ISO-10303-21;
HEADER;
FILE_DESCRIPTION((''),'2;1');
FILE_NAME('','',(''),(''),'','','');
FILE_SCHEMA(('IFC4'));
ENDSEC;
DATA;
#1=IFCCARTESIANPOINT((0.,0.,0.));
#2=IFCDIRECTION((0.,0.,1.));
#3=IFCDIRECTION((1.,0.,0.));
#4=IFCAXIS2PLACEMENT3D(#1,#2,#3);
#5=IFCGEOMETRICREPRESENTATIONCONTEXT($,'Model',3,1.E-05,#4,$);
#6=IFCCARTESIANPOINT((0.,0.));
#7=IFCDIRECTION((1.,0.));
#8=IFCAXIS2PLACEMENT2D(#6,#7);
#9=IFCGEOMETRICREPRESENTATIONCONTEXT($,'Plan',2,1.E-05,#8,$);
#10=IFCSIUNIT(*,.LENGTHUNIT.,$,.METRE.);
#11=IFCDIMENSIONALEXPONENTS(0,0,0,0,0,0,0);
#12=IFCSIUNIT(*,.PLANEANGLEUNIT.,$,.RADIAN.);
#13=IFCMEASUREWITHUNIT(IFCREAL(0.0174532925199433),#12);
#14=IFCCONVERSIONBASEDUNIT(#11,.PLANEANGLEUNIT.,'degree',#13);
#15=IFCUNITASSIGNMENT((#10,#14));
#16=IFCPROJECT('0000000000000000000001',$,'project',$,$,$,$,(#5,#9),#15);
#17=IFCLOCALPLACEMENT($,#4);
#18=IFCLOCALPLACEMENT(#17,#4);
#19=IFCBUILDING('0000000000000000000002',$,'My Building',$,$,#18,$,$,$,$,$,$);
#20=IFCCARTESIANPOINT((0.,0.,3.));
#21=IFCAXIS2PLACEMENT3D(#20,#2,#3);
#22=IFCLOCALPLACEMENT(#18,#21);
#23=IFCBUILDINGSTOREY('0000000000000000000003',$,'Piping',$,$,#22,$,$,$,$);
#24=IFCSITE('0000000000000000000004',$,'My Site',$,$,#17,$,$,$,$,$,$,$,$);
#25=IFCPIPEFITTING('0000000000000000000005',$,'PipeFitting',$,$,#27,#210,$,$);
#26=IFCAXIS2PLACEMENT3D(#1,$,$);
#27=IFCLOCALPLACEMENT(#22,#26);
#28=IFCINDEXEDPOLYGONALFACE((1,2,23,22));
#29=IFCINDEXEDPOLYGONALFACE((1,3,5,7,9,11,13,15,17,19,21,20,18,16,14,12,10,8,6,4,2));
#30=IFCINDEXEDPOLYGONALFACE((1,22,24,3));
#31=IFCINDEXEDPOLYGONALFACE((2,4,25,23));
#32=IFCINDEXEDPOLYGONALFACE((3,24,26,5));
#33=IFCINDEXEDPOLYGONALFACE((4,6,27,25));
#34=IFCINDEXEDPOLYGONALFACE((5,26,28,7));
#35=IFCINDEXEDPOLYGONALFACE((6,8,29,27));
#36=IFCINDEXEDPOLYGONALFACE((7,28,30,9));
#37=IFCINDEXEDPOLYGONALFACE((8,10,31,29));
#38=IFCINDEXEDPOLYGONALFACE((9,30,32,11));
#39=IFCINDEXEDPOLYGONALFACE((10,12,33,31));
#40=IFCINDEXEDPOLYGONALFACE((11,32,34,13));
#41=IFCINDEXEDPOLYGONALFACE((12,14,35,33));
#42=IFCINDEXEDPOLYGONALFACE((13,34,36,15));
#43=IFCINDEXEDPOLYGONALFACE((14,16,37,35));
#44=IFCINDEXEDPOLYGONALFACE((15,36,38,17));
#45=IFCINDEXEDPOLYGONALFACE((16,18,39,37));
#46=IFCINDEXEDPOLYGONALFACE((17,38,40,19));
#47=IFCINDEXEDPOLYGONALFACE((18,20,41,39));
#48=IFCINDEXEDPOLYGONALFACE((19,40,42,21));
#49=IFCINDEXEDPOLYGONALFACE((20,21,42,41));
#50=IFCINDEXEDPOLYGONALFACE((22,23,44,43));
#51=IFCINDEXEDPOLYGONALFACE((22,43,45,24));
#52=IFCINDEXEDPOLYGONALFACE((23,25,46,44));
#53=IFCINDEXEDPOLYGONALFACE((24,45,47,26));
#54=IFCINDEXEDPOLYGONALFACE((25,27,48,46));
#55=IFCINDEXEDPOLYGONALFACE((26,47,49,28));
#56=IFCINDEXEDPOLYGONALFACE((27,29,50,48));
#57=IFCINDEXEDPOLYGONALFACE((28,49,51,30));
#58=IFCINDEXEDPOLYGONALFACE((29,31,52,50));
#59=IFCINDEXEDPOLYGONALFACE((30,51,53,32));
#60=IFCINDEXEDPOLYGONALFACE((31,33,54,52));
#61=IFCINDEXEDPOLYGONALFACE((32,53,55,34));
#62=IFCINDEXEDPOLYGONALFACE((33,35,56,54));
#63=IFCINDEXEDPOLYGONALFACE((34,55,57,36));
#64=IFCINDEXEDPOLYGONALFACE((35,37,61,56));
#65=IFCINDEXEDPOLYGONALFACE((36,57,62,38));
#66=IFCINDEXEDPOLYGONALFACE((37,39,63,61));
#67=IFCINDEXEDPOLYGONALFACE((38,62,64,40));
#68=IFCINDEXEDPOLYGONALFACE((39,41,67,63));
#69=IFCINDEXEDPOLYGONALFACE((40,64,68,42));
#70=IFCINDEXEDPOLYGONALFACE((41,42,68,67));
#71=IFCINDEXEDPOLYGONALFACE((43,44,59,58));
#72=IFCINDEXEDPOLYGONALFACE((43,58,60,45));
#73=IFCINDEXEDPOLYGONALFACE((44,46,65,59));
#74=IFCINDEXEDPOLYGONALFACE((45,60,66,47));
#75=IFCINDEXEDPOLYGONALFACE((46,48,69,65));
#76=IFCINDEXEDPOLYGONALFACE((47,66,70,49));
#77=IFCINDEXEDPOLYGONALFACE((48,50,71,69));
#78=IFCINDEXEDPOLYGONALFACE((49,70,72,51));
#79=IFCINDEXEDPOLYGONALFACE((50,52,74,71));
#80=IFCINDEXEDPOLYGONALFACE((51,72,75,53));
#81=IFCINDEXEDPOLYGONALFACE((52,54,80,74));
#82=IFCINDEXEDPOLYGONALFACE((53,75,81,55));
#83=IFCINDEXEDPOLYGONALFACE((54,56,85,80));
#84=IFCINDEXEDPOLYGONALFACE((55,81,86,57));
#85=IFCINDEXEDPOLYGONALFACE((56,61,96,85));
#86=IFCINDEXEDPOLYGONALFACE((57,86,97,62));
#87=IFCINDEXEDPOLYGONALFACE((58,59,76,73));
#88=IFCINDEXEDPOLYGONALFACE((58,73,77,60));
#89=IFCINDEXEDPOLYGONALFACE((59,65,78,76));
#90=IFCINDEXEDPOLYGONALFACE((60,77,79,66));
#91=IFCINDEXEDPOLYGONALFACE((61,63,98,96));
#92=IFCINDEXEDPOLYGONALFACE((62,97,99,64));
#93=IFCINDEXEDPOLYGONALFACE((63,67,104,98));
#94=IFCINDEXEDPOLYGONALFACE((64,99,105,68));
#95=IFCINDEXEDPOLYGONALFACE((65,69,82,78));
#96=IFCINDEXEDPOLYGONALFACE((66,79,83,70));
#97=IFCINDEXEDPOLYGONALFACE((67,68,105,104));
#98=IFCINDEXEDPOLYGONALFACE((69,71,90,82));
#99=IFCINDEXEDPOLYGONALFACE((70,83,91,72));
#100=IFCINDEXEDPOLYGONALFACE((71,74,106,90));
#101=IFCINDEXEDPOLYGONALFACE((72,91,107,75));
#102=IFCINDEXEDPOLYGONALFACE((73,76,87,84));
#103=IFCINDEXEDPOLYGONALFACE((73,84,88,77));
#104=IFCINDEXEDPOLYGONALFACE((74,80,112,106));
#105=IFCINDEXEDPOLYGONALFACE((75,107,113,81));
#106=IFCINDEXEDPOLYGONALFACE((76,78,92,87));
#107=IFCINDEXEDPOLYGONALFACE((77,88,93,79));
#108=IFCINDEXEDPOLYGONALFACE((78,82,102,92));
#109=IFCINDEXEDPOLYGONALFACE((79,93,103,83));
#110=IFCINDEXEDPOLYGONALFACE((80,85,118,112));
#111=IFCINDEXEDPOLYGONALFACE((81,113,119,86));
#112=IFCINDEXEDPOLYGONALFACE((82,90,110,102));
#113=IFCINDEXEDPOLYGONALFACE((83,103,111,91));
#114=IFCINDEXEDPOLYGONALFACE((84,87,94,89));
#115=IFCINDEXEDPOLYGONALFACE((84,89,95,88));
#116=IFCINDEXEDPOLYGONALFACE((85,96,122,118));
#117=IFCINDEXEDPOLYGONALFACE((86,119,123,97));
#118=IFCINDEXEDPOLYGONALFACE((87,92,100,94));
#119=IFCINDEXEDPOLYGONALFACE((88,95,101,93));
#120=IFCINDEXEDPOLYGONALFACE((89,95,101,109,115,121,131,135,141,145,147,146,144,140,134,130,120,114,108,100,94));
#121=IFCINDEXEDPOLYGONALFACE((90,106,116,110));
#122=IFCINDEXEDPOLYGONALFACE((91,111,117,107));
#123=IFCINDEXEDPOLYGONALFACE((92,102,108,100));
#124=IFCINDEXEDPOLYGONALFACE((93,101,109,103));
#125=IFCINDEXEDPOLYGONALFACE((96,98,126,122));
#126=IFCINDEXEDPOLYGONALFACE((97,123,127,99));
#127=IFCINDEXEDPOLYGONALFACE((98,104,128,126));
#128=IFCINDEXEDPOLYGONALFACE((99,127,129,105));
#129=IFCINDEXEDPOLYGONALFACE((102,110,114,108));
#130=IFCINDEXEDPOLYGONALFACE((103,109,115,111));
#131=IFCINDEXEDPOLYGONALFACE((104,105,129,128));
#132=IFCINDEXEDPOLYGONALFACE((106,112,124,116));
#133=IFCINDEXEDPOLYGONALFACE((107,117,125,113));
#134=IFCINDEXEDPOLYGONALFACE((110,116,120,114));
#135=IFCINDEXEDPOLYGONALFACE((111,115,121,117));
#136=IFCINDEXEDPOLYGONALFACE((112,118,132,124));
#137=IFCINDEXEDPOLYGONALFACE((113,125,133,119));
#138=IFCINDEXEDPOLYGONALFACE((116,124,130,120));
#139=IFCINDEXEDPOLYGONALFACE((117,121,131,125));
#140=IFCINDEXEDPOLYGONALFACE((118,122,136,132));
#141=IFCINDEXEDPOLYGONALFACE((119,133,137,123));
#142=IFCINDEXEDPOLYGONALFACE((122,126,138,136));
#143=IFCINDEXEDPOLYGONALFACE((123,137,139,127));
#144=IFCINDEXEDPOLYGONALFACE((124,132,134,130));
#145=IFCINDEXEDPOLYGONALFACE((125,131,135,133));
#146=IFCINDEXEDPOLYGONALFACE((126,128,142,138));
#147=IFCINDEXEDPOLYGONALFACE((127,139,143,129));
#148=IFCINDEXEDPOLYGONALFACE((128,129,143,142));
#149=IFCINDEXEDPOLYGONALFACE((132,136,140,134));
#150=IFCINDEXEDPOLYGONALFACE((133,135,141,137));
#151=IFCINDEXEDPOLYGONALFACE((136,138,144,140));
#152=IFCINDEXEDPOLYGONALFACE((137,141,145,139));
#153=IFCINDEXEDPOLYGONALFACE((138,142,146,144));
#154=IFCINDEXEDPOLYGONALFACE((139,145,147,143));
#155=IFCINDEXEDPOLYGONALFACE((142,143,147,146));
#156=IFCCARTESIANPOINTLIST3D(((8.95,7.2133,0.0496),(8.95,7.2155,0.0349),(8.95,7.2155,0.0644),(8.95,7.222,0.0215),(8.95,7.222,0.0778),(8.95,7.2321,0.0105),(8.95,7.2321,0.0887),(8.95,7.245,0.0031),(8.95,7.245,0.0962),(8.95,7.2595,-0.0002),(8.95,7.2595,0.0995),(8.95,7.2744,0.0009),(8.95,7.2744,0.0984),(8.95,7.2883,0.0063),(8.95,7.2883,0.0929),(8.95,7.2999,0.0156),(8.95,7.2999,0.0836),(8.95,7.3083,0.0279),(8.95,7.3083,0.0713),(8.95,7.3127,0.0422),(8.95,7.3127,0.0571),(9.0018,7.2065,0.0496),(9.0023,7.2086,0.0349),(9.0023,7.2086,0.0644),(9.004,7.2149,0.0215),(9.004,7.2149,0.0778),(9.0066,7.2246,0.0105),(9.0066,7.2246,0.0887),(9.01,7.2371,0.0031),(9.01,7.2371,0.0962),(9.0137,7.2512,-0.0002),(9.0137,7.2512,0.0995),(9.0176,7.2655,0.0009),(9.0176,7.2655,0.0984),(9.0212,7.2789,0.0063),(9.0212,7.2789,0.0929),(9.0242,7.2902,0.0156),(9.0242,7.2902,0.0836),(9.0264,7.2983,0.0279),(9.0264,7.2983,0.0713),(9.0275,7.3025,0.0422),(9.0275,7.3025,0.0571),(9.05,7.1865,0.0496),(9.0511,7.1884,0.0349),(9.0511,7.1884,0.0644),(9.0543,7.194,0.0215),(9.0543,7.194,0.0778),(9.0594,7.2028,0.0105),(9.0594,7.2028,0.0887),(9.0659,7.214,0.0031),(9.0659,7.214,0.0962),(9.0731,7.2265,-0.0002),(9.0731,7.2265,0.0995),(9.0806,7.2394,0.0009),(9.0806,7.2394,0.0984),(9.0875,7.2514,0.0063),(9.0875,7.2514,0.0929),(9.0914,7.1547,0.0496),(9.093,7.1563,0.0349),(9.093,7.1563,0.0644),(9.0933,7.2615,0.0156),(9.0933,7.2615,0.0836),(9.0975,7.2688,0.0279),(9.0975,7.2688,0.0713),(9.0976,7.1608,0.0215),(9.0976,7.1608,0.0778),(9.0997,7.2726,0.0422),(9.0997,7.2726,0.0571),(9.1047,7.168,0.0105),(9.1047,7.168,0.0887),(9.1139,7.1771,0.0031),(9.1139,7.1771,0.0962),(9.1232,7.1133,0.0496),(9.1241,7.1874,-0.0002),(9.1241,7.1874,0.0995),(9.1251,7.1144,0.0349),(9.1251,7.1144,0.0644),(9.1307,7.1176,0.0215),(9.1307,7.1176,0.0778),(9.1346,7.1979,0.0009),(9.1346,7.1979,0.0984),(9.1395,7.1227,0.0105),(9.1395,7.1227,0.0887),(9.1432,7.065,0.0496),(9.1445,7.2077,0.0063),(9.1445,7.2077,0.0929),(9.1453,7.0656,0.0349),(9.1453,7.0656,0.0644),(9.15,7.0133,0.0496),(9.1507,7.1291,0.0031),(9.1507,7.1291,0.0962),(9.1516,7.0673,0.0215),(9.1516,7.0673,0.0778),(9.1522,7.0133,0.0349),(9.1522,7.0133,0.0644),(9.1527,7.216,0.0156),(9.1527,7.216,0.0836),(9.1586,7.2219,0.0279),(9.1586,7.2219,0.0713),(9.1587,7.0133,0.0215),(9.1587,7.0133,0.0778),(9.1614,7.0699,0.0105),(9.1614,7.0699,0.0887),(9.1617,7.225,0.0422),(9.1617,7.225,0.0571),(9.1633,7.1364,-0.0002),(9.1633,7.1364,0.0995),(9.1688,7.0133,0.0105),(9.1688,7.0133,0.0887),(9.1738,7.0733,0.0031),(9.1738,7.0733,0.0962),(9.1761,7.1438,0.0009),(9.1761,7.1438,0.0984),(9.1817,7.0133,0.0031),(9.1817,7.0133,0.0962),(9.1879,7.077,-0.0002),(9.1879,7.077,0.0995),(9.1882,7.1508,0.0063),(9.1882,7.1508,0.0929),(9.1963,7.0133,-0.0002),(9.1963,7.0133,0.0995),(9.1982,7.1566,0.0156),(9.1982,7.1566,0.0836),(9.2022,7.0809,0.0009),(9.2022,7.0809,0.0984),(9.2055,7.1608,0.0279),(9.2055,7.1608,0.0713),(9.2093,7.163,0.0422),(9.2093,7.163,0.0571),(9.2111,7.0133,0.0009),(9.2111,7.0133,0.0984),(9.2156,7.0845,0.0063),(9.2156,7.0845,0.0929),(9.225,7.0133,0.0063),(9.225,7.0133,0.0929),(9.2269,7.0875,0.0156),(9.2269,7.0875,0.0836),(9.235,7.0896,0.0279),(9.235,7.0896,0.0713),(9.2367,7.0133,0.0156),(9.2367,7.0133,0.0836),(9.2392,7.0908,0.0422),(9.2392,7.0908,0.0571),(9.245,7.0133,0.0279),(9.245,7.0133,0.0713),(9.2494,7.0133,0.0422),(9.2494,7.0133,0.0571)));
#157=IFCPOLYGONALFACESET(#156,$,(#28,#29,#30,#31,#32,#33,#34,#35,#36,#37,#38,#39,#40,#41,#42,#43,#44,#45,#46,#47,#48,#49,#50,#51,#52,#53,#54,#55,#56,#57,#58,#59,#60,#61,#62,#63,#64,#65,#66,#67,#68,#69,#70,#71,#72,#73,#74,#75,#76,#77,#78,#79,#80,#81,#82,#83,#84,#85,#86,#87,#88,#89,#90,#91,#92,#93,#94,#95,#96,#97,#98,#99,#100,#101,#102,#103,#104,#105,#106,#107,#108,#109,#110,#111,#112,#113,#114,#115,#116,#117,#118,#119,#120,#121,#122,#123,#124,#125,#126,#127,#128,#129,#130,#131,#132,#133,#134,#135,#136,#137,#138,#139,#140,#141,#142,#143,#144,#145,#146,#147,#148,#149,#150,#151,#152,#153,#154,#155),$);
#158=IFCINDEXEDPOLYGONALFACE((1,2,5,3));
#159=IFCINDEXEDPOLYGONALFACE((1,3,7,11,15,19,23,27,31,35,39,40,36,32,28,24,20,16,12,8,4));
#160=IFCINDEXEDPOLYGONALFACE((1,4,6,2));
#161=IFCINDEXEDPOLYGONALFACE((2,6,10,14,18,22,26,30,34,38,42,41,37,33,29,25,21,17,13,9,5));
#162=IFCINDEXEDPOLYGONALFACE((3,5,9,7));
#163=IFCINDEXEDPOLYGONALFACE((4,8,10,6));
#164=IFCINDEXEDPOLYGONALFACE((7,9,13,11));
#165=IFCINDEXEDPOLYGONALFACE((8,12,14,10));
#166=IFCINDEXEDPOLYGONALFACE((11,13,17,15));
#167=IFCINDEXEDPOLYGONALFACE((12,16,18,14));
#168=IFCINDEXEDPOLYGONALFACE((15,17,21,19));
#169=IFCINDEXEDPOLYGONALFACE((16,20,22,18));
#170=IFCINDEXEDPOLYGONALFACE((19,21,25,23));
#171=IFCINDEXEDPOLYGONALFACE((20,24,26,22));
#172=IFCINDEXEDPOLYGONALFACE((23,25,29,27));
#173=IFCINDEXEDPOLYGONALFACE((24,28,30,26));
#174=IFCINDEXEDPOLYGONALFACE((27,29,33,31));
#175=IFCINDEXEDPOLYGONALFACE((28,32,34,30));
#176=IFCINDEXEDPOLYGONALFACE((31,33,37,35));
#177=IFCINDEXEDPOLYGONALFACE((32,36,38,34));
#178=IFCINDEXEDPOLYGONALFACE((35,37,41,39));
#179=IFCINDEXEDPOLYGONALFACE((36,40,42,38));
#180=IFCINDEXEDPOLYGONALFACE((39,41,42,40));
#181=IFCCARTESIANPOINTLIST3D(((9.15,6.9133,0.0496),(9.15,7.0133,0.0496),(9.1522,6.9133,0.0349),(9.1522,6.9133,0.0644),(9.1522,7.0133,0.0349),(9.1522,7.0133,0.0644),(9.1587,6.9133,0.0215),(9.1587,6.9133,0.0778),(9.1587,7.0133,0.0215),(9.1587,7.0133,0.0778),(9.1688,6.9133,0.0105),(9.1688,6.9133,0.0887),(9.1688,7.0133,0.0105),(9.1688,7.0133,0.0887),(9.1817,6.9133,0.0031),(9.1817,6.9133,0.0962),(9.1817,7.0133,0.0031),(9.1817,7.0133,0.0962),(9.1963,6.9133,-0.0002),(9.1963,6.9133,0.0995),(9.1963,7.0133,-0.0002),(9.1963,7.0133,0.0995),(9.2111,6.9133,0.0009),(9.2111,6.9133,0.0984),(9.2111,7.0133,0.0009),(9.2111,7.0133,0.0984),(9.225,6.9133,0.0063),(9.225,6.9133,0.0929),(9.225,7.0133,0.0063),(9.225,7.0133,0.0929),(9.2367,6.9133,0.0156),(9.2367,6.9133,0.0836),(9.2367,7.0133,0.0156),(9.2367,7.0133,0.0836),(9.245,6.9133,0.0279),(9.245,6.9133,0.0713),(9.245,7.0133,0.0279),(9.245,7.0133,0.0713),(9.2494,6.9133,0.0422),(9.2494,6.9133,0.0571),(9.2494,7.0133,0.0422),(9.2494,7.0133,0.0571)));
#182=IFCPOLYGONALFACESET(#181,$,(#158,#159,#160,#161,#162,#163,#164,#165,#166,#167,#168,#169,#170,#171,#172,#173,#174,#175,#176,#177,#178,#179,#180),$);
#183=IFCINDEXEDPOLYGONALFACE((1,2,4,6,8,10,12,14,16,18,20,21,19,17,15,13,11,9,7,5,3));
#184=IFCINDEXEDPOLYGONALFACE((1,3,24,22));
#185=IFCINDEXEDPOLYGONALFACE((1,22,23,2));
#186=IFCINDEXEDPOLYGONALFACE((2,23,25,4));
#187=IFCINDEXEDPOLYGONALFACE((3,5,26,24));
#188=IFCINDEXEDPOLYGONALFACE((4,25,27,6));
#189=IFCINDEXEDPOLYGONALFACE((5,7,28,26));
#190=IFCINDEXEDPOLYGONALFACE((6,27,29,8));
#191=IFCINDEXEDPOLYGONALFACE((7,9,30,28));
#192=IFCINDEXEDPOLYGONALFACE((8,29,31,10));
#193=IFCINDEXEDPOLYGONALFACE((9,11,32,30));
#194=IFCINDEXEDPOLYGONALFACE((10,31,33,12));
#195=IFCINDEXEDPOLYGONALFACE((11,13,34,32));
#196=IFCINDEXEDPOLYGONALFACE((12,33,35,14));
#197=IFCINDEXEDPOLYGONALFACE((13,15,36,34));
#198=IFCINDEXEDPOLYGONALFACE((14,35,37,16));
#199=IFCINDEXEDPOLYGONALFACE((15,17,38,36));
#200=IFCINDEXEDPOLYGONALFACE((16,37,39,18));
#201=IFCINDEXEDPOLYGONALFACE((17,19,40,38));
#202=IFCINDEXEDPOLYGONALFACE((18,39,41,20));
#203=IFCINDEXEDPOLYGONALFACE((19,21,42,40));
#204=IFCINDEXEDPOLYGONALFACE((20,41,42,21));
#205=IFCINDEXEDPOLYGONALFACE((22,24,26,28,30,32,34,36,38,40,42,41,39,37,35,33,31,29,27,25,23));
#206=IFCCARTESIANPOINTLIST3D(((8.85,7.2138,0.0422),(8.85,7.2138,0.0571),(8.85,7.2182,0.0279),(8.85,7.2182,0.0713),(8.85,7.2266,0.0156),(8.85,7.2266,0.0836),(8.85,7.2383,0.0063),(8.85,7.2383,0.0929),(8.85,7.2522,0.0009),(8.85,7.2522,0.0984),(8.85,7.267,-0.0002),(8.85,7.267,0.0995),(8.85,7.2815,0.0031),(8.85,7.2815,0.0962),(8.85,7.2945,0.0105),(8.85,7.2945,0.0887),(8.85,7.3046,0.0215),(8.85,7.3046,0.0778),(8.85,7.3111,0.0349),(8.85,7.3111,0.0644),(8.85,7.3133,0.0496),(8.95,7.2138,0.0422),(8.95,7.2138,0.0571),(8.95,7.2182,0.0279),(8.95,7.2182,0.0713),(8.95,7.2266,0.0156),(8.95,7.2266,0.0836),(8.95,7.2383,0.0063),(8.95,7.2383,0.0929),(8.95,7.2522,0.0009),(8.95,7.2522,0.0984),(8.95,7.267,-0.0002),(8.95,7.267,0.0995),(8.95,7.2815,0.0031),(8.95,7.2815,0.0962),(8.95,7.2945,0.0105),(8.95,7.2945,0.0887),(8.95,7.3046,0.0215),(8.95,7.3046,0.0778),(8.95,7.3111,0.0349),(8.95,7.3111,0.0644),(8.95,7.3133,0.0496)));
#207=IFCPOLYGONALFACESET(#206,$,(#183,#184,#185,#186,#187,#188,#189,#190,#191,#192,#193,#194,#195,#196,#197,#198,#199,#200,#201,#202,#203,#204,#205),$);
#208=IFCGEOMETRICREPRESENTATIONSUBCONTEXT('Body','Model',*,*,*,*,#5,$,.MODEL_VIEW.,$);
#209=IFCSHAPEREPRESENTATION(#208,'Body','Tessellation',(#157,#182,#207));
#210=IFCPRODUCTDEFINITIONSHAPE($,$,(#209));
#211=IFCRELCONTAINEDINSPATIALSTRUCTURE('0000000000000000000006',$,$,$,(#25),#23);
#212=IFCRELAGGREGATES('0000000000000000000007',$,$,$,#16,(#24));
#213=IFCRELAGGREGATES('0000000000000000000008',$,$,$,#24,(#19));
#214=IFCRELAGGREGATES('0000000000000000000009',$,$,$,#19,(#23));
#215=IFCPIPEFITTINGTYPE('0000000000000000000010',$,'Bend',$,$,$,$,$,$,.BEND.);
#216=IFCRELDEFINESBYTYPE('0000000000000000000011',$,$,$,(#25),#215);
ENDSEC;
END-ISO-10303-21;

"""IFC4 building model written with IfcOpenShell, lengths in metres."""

from ifc_helpers import new_model, entity, si_unit, converted_unit, frame, origin_with_axes, origin_2d_with_axis, place, context, subcontext, project, spatial, circle, extrude, source, transform, mapped, type_object, type_shapes, element, save


model = new_model("IFC4")

# Units and contexts
model_context = context("Model", 3, precision=1e-05, world=origin_with_axes())
plan_context = context("Plan", 2, precision=1e-05, world=origin_2d_with_axis())
body_context = subcontext(model_context, "Body", "Model", "MODEL_VIEW")
ifc_project = project(units=[si_unit("LENGTHUNIT", "METRE"), converted_unit("PLANEANGLEUNIT", "degree", entity("IfcReal", 0.0174532925199433), si_unit("PLANEANGLEUNIT", "RADIAN"), dimensions=[0, 0, 0, 0, 0, 0, 0])], contexts=[model_context, plan_context])

# Site, building, storey
site_placement = place(None, origin_with_axes())
site = spatial("IfcSite", under=ifc_project, at=site_placement, Name="My Site")
building_placement = place(site_placement, origin_with_axes())
building = spatial("IfcBuilding", under=site, at=building_placement, Name="My Building")
storey_placement = place(building_placement, frame((0.0, 0.0, 3.0), z_axis=(0.0, 0.0, 1.0), x_axis=(1.0, 0.0, 0.0)))
storey = spatial("IfcBuildingStorey", under=building, at=storey_placement, Name="Piping")

# Pipe fitting
pipe_fitting_type_1 = type_object("IfcPipeFittingType", Name="Bend", PredefinedType="BEND")
shared_shape_1 = source(origin_with_axes(), body_context, "Body", "SolidModel", [
    entity("IfcSweptDiskSolid", entity("IfcIndexedPolyCurve", entity("IfcCartesianPointList3D", [[0.0, 0.0, 0.1], [0.0732, 0.0, 0.2768], [0.25, 0.0, 0.35]]), [entity("IfcArcIndex", [1, 2, 3])]), 0.05),
    extrude(circle(Radius=0.05), origin_with_axes(), (0.0, 0.0, 1.0), 0.1),
    extrude(circle(Radius=0.05), frame((0.25, 0.0, 0.35), z_axis=(1.0, 0.0, 0.0), x_axis=(0.0, 0.0, 1.0)), (0.0, 0.0, 1.0), 0.1),
])
type_shapes(pipe_fitting_type_1, [shared_shape_1])
for number, where, z_axis, x_axis, name in (
    (1, (9.2, 6.9133, 0.0496), (0.0, 1.0, 0.0), (-1.0, 0.0, 0.0), "PipeFitting"),
):
    element("IfcPipeFitting", number, at=place(storey_placement, frame(where, z_axis=z_axis, x_axis=x_axis)), inside=storey, type_object=pipe_fitting_type_1, Name=name, context=body_context, shape_type="MappedRepresentation", body=[
        mapped(shared_shape_1, transform((0.0, 0.0, 0.0), x_axis=(1.0, 0.0, 0.0), y_axis=(0.0, 1.0, 0.0), z_axis=(0.0, 0.0, 1.0), scale=1.0)),
    ])

save(model, "model.ifc")
